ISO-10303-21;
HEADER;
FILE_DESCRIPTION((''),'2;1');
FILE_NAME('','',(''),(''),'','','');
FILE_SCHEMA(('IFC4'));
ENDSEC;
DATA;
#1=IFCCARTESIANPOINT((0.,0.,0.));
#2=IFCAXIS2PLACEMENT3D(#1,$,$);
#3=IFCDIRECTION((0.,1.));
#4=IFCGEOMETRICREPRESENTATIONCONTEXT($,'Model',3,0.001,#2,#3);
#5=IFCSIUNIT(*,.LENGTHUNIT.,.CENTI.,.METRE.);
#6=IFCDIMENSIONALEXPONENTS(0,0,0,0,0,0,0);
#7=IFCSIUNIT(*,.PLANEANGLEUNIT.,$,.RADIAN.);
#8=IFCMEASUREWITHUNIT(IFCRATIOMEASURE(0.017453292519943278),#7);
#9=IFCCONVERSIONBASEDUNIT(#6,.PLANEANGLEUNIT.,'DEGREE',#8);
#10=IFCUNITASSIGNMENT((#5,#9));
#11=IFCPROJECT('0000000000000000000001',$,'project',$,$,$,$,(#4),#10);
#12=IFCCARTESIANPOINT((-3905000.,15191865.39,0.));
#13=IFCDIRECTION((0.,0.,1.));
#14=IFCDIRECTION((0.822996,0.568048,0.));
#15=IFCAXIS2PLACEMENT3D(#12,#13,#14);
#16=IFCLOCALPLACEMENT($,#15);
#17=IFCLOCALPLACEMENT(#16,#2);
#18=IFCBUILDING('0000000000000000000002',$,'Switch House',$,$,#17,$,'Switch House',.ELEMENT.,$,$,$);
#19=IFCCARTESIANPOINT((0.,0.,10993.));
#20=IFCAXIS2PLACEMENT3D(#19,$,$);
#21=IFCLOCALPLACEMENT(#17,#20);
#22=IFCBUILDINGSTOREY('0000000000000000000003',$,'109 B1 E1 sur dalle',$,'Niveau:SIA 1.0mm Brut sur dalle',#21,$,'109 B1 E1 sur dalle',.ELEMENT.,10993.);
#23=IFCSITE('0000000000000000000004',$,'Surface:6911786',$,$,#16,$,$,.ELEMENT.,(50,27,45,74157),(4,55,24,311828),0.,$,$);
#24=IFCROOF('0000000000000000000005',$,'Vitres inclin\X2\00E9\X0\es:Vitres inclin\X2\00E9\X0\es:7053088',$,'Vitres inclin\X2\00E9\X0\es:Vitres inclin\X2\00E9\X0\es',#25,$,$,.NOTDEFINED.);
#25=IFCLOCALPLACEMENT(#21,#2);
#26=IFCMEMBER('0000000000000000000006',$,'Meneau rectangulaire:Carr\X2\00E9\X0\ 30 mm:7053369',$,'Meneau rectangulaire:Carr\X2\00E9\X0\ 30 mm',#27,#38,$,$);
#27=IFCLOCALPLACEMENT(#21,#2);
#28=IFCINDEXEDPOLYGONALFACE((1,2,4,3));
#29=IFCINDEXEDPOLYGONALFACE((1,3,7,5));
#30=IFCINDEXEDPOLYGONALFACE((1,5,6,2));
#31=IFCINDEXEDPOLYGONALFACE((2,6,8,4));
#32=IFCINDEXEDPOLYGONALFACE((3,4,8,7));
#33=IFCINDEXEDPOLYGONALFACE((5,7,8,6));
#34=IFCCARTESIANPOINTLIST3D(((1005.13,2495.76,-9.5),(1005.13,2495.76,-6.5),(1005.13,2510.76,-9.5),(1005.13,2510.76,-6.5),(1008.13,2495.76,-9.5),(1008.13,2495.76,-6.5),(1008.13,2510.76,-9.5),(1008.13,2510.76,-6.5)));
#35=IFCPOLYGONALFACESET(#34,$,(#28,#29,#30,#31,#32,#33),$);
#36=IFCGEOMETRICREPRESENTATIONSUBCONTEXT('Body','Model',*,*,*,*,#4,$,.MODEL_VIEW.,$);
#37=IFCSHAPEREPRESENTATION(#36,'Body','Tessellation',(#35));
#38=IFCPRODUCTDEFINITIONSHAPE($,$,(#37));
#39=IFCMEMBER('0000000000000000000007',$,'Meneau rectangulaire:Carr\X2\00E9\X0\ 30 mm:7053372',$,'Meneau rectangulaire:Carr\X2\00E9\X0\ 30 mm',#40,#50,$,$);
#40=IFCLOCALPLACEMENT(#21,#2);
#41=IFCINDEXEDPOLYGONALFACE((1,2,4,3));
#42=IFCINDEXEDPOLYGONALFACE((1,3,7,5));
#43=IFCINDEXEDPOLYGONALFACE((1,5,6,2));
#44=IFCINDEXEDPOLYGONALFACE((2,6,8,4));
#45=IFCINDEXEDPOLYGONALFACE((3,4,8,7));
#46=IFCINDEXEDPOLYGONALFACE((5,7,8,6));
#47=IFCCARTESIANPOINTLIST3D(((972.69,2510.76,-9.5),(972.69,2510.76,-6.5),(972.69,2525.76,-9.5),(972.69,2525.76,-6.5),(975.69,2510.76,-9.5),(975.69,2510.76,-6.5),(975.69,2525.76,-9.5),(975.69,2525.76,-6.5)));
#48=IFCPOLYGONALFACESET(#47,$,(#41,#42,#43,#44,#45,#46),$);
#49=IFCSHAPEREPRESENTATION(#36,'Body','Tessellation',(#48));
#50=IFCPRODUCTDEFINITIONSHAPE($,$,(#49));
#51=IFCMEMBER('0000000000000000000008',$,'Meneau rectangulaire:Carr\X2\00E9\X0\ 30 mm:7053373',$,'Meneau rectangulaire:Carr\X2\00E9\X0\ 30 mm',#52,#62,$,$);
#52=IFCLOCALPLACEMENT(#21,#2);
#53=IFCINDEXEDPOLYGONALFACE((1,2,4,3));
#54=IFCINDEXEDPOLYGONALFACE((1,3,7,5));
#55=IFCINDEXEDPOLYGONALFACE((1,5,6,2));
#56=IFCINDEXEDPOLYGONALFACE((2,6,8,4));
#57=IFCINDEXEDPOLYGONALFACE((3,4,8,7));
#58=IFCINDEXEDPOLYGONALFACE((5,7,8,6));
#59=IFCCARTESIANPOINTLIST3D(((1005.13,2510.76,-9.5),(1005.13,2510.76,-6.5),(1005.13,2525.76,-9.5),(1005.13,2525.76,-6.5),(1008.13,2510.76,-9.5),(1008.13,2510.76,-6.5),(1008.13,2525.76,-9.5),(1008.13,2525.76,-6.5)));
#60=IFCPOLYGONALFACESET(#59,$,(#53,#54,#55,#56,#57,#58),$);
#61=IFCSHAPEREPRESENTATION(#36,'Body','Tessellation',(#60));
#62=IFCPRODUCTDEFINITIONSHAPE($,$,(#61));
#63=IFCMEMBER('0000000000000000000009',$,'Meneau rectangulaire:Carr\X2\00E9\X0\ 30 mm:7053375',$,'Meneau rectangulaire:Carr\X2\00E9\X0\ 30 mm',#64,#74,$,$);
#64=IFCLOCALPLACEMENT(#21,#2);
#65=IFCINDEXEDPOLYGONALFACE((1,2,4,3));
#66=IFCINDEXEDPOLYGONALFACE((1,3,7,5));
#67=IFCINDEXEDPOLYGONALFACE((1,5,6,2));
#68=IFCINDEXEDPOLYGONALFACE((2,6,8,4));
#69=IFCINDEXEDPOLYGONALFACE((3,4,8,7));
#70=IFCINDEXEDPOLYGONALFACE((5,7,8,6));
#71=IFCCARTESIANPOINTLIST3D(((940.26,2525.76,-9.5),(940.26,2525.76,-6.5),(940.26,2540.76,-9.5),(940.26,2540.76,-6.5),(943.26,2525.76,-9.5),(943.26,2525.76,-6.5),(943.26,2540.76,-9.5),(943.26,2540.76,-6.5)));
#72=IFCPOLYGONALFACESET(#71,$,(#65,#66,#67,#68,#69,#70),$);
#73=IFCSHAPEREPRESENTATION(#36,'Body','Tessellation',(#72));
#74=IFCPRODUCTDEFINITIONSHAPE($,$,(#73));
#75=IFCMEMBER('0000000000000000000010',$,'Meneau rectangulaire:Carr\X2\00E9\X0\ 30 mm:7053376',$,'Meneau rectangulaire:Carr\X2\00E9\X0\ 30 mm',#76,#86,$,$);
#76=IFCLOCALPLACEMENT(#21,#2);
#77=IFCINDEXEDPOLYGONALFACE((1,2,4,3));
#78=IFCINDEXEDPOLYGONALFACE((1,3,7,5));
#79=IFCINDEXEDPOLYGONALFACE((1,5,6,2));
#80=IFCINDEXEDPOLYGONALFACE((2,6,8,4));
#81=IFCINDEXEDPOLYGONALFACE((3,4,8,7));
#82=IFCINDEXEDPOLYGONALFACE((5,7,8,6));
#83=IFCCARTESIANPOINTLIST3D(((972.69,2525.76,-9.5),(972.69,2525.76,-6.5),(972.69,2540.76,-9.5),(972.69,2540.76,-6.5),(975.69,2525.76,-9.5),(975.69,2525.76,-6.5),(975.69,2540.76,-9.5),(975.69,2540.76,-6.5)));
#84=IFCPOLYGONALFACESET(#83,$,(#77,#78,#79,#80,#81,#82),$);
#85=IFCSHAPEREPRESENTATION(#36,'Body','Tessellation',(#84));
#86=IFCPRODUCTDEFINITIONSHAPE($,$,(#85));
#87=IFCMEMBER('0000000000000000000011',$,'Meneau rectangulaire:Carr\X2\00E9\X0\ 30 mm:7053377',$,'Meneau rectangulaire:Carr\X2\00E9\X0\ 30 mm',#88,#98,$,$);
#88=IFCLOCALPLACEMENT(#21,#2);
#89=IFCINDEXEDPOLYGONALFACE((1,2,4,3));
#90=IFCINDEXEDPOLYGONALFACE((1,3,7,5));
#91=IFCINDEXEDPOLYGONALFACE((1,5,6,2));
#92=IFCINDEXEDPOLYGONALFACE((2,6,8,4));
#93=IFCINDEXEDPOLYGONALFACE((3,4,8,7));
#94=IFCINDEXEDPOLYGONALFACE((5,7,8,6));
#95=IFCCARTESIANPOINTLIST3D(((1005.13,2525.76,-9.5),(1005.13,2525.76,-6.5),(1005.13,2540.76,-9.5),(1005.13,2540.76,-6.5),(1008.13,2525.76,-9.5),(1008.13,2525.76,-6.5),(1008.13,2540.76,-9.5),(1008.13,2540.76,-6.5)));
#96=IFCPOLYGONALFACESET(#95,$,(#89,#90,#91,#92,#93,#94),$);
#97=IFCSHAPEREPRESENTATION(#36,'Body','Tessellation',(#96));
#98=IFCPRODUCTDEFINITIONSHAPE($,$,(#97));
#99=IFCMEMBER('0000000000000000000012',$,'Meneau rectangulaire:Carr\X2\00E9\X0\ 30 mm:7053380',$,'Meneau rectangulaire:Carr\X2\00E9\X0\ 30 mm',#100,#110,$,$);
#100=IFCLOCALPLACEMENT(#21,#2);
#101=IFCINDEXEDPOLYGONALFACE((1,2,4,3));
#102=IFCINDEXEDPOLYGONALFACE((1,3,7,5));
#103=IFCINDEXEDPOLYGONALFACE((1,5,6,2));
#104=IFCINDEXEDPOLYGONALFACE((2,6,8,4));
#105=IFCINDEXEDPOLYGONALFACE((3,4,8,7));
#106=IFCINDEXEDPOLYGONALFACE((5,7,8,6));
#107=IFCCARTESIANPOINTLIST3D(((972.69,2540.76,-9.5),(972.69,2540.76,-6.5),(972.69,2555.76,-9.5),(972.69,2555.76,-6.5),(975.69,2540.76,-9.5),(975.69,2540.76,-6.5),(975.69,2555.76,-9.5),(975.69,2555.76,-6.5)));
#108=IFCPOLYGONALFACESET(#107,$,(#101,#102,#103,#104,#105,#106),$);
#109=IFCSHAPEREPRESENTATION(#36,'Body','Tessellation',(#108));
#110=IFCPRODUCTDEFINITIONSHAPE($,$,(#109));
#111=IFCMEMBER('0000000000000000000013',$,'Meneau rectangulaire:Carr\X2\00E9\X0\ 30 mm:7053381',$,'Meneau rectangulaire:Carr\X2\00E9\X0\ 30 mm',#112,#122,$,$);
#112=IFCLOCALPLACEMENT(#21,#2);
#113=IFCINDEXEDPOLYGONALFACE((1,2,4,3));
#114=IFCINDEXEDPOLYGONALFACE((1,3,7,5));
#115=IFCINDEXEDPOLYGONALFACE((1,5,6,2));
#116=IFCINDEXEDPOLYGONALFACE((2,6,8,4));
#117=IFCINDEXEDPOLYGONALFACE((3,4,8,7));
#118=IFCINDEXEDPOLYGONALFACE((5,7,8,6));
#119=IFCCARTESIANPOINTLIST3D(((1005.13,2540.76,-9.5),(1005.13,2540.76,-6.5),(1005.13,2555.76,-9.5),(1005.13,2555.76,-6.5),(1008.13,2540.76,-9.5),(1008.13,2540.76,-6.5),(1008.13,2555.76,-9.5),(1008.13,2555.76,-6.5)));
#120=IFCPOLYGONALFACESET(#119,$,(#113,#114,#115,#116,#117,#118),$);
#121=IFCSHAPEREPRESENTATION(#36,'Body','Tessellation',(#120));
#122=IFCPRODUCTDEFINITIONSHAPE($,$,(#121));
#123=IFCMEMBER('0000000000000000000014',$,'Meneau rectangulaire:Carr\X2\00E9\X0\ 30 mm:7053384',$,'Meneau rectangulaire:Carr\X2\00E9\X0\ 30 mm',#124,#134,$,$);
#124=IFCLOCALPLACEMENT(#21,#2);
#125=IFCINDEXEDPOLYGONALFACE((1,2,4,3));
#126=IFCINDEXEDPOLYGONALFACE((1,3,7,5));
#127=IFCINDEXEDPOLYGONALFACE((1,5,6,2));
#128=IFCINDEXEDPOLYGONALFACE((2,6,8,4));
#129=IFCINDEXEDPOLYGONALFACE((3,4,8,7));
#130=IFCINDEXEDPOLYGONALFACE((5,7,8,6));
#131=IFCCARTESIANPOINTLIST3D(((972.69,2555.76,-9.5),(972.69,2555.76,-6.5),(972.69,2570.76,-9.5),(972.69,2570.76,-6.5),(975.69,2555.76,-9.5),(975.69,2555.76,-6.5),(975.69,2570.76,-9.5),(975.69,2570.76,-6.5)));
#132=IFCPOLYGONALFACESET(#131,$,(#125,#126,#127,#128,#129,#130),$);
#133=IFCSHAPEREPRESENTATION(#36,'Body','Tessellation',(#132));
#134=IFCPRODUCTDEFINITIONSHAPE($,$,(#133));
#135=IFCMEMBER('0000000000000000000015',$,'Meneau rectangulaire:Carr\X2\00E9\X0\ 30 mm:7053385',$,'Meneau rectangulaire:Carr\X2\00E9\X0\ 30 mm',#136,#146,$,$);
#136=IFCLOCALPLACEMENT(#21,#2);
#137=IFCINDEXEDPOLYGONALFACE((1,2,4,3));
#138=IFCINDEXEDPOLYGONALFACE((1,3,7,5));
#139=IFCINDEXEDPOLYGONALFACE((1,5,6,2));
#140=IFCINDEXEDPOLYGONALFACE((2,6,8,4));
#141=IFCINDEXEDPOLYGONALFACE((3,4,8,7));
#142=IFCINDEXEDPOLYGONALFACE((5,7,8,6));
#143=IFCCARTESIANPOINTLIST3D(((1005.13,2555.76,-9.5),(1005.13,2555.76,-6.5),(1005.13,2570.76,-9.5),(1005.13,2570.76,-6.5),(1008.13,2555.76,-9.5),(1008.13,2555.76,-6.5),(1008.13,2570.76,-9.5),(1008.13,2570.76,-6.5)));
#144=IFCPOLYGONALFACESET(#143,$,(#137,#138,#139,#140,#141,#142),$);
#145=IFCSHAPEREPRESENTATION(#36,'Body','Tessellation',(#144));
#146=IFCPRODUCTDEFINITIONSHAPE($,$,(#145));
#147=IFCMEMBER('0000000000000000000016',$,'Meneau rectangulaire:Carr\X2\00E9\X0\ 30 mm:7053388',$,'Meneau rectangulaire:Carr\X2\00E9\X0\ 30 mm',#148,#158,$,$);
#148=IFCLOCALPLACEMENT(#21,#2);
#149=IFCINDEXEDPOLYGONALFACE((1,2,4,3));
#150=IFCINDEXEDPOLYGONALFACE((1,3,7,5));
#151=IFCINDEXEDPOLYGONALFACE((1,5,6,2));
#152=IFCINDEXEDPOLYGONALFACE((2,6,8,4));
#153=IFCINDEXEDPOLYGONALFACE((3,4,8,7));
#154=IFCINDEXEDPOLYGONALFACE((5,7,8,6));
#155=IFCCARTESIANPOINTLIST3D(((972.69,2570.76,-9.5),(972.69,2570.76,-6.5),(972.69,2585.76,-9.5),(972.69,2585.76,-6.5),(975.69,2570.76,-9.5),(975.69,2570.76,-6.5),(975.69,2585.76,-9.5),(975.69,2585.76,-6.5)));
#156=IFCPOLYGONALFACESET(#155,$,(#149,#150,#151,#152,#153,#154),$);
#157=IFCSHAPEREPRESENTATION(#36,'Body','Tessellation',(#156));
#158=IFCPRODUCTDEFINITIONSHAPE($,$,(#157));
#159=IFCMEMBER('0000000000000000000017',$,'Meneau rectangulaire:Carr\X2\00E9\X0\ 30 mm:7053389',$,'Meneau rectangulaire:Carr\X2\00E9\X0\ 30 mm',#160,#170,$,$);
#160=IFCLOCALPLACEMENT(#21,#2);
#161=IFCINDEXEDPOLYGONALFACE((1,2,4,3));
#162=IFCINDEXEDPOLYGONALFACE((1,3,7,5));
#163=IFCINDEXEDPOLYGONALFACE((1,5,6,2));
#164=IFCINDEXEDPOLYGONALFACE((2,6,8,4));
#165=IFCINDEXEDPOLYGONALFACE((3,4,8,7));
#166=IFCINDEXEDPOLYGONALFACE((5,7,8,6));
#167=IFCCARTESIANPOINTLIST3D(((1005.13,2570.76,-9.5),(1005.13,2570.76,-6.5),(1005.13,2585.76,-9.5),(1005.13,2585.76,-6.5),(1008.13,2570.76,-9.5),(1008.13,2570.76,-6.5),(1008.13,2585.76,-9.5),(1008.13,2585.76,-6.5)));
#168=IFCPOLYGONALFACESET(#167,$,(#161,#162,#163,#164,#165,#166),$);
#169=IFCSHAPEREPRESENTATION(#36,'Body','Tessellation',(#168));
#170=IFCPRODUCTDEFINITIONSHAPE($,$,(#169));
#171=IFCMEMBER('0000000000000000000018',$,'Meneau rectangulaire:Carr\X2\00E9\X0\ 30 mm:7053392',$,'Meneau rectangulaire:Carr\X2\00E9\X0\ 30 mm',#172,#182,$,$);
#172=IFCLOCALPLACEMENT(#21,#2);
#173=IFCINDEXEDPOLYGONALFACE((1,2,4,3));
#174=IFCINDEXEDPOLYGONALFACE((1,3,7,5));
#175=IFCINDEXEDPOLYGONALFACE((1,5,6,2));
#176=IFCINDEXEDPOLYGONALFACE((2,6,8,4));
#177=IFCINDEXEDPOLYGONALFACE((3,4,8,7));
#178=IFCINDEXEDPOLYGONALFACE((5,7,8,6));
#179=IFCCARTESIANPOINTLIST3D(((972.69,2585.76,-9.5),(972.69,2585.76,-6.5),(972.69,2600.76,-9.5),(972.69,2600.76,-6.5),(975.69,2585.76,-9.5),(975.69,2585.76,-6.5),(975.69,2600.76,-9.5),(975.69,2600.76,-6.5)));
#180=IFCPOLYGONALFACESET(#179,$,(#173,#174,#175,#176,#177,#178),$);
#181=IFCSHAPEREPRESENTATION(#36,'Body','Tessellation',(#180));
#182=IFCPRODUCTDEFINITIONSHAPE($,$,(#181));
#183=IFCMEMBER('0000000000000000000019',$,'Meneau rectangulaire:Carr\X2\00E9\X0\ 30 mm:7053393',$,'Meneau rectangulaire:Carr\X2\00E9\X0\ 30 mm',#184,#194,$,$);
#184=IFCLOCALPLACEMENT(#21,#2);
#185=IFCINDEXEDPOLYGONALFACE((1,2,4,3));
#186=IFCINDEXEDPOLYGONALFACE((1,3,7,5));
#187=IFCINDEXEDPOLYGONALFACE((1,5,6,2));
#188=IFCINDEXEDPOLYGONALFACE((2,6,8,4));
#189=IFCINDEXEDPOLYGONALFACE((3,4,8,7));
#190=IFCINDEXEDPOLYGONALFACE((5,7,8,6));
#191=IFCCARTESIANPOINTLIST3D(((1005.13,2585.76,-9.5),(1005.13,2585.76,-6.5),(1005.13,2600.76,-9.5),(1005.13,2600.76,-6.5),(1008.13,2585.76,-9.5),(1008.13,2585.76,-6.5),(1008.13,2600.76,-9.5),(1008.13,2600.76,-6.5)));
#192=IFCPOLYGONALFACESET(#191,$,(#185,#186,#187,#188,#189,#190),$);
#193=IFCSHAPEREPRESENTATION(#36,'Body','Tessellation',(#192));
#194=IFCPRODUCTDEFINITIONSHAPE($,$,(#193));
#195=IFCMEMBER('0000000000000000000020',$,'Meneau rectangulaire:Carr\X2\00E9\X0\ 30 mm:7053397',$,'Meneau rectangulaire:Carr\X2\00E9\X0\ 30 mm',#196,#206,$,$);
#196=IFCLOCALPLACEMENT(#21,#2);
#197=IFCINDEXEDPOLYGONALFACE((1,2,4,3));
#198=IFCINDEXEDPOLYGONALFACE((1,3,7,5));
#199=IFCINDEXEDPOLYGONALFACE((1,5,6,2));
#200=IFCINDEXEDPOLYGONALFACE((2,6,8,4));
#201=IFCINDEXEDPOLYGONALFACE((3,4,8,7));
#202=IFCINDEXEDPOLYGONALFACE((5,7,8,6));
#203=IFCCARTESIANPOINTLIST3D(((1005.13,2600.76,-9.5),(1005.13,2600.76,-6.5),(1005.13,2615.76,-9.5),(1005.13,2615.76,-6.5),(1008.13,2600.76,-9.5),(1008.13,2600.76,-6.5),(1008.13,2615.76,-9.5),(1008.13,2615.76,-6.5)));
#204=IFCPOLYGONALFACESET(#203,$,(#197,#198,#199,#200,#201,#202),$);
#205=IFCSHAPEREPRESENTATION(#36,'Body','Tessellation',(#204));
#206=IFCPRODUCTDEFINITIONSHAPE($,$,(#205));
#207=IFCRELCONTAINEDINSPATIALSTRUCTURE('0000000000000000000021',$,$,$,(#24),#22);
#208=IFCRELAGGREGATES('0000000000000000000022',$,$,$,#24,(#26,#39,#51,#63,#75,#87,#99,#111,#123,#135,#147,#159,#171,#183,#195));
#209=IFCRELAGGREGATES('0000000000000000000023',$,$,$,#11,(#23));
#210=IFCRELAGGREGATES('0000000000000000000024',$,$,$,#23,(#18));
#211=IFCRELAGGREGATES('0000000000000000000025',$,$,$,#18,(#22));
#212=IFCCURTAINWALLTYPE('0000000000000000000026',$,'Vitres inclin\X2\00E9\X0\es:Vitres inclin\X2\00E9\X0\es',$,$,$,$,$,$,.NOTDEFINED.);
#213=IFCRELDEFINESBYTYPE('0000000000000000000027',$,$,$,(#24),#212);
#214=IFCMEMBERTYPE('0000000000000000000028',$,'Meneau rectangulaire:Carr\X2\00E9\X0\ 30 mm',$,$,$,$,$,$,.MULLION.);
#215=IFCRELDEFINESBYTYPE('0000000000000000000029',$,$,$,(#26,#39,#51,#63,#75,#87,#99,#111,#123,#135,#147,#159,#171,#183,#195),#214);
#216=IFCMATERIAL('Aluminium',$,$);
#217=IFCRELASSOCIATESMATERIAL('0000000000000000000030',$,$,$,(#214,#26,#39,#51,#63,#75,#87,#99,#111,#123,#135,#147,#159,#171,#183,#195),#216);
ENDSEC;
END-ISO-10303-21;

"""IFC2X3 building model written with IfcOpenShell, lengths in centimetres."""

from ifc_helpers import new_model, entity, si_unit, converted_unit, direction, frame, origin, origin_2d_with_axis, place, context, subcontext, project, spatial, rectangle, extrude, source, transform, mapped, material, type_object, type_shapes, element, aggregate, save


model = new_model("IFC2X3")

# Units and contexts
model_context = context("Model", 3, precision=0.001, world=origin(), true_north=direction((0.0, 1.0)))
body_context = subcontext(model_context, "Body", "Model", "MODEL_VIEW")
ifc_project = project(units=[si_unit("LENGTHUNIT", "METRE", prefix="CENTI"), converted_unit("PLANEANGLEUNIT", "DEGREE", entity("IfcRatioMeasure", 0.017453292519943278), si_unit("PLANEANGLEUNIT", "RADIAN"), dimensions=[0, 0, 0, 0, 0, 0, 0])], contexts=[model_context])

# Site, building, storey
site_placement = place(None, frame((-3905000.0, 15191865.39, 0.0), z_axis=(0.0, 0.0, 1.0), x_axis=(0.822996, 0.568048, 0.0)))
site = spatial("IfcSite", under=ifc_project, at=site_placement, Name="Surface:6911786", CompositionType="ELEMENT", RefLatitude=(50, 27, 45, 74157), RefLongitude=(4, 55, 24, 311828), RefElevation=0.0)
building_placement = place(site_placement, origin())
building = spatial("IfcBuilding", under=site, at=building_placement, Name="Switch House", LongName="Switch House", CompositionType="ELEMENT")
storey_placement = place(building_placement, frame((0.0, 0.0, 10993.0)))
storey = spatial("IfcBuildingStorey", under=building, at=storey_placement, Name="109 B1 E1 sur dalle", ObjectType="Niveau:SIA 1.0mm Brut sur dalle", LongName="109 B1 E1 sur dalle", CompositionType="ELEMENT", Elevation=10993.0)

# Roof, members
curtain_wall_type = type_object("IfcCurtainWallType", Name="Vitres inclinées:Vitres inclinées", PredefinedType="NOTDEFINED")
roof_placement = place(storey_placement, frame((0.0, 0.0, -10993.0)))
roof = element("IfcRoof", 1, at=roof_placement, inside=storey, type_object=curtain_wall_type, Name="Vitres inclinées:Vitres inclinées:7053088", ObjectType="Vitres inclinées:Vitres inclinées", ShapeType="NOTDEFINED")
ifc_material = material(Name="Aluminium")
member_type_1 = type_object("IfcMemberType", Name="Meneau rectangulaire:Carré 30 mm", PredefinedType="MULLION", material=ifc_material)
shared_shape_1 = source(origin(), body_context, "Body", "SweptSolid", [
    extrude(rectangle(XDim=3.0, YDim=3.0, at=origin_2d_with_axis()), frame((0.0, 0.0, -15.0), z_axis=(0.0, 0.0, 1.0), x_axis=(0.0, -1.0, 0.0)), (0.0, 0.0, 1.0), 15.0),
])
type_shapes(member_type_1, [shared_shape_1])
member_1_placement = place(roof_placement, frame((1006.63, 2510.76, 10985.0), z_axis=(0.0, 1.0, 0.0), x_axis=(1.0, 0.0, 0.0)))
member_1 = element("IfcMember", 2, at=member_1_placement, type_object=member_type_1, material=ifc_material, Name="Meneau rectangulaire:Carré 30 mm:7053369", ObjectType="Meneau rectangulaire:Carré 30 mm", context=body_context, shape_type="MappedRepresentation", body=[
    mapped(shared_shape_1, transform((0.0, 0.0, 0.0), scale=1.0)),
])
member_2_placement = place(roof_placement, frame((974.19, 2525.76, 10985.0), z_axis=(0.0, 1.0, 0.0), x_axis=(1.0, 0.0, 0.0)))
member_2 = element("IfcMember", 3, at=member_2_placement, type_object=member_type_1, material=ifc_material, Name="Meneau rectangulaire:Carré 30 mm:7053372", ObjectType="Meneau rectangulaire:Carré 30 mm", context=body_context, shape_type="MappedRepresentation", body=[
    mapped(shared_shape_1, transform((0.0, 0.0, 0.0), scale=1.0)),
])
member_3_placement = place(roof_placement, frame((1006.63, 2525.76, 10985.0), z_axis=(0.0, 1.0, 0.0), x_axis=(1.0, 0.0, 0.0)))
member_3 = element("IfcMember", 4, at=member_3_placement, type_object=member_type_1, material=ifc_material, Name="Meneau rectangulaire:Carré 30 mm:7053373", ObjectType="Meneau rectangulaire:Carré 30 mm", context=body_context, shape_type="MappedRepresentation", body=[
    mapped(shared_shape_1, transform((0.0, 0.0, 0.0), scale=1.0)),
])
member_4_placement = place(roof_placement, frame((941.76, 2540.76, 10985.0), z_axis=(0.0, 1.0, 0.0), x_axis=(1.0, 0.0, 0.0)))
member_4 = element("IfcMember", 5, at=member_4_placement, type_object=member_type_1, material=ifc_material, Name="Meneau rectangulaire:Carré 30 mm:7053375", ObjectType="Meneau rectangulaire:Carré 30 mm", context=body_context, shape_type="MappedRepresentation", body=[
    mapped(shared_shape_1, transform((0.0, 0.0, 0.0), scale=1.0)),
])
member_5_placement = place(roof_placement, frame((974.19, 2540.76, 10985.0), z_axis=(0.0, 1.0, 0.0), x_axis=(1.0, 0.0, 0.0)))
member_5 = element("IfcMember", 6, at=member_5_placement, type_object=member_type_1, material=ifc_material, Name="Meneau rectangulaire:Carré 30 mm:7053376", ObjectType="Meneau rectangulaire:Carré 30 mm", context=body_context, shape_type="MappedRepresentation", body=[
    mapped(shared_shape_1, transform((0.0, 0.0, 0.0), scale=1.0)),
])
member_6_placement = place(roof_placement, frame((1006.63, 2540.76, 10985.0), z_axis=(0.0, 1.0, 0.0), x_axis=(1.0, 0.0, 0.0)))
member_6 = element("IfcMember", 7, at=member_6_placement, type_object=member_type_1, material=ifc_material, Name="Meneau rectangulaire:Carré 30 mm:7053377", ObjectType="Meneau rectangulaire:Carré 30 mm", context=body_context, shape_type="MappedRepresentation", body=[
    mapped(shared_shape_1, transform((0.0, 0.0, 0.0), scale=1.0)),
])
member_7_placement = place(roof_placement, frame((974.19, 2555.76, 10985.0), z_axis=(0.0, 1.0, 0.0), x_axis=(1.0, 0.0, 0.0)))
member_7 = element("IfcMember", 8, at=member_7_placement, type_object=member_type_1, material=ifc_material, Name="Meneau rectangulaire:Carré 30 mm:7053380", ObjectType="Meneau rectangulaire:Carré 30 mm", context=body_context, shape_type="MappedRepresentation", body=[
    mapped(shared_shape_1, transform((0.0, 0.0, 0.0), scale=1.0)),
])
member_8_placement = place(roof_placement, frame((1006.63, 2555.76, 10985.0), z_axis=(0.0, 1.0, 0.0), x_axis=(1.0, 0.0, 0.0)))
member_8 = element("IfcMember", 9, at=member_8_placement, type_object=member_type_1, material=ifc_material, Name="Meneau rectangulaire:Carré 30 mm:7053381", ObjectType="Meneau rectangulaire:Carré 30 mm", context=body_context, shape_type="MappedRepresentation", body=[
    mapped(shared_shape_1, transform((0.0, 0.0, 0.0), scale=1.0)),
])
member_9_placement = place(roof_placement, frame((974.19, 2570.76, 10985.0), z_axis=(0.0, 1.0, 0.0), x_axis=(1.0, 0.0, 0.0)))
member_9 = element("IfcMember", 10, at=member_9_placement, type_object=member_type_1, material=ifc_material, Name="Meneau rectangulaire:Carré 30 mm:7053384", ObjectType="Meneau rectangulaire:Carré 30 mm", context=body_context, shape_type="MappedRepresentation", body=[
    mapped(shared_shape_1, transform((0.0, 0.0, 0.0), scale=1.0)),
])
member_10_placement = place(roof_placement, frame((1006.63, 2570.76, 10985.0), z_axis=(0.0, 1.0, 0.0), x_axis=(1.0, 0.0, 0.0)))
member_10 = element("IfcMember", 11, at=member_10_placement, type_object=member_type_1, material=ifc_material, Name="Meneau rectangulaire:Carré 30 mm:7053385", ObjectType="Meneau rectangulaire:Carré 30 mm", context=body_context, shape_type="MappedRepresentation", body=[
    mapped(shared_shape_1, transform((0.0, 0.0, 0.0), scale=1.0)),
])
member_11_placement = place(roof_placement, frame((974.19, 2585.76, 10985.0), z_axis=(0.0, 1.0, 0.0), x_axis=(1.0, 0.0, 0.0)))
member_11 = element("IfcMember", 12, at=member_11_placement, type_object=member_type_1, material=ifc_material, Name="Meneau rectangulaire:Carré 30 mm:7053388", ObjectType="Meneau rectangulaire:Carré 30 mm", context=body_context, shape_type="MappedRepresentation", body=[
    mapped(shared_shape_1, transform((0.0, 0.0, 0.0), scale=1.0)),
])
member_12_placement = place(roof_placement, frame((1006.63, 2585.76, 10985.0), z_axis=(0.0, 1.0, 0.0), x_axis=(1.0, 0.0, 0.0)))
member_12 = element("IfcMember", 13, at=member_12_placement, type_object=member_type_1, material=ifc_material, Name="Meneau rectangulaire:Carré 30 mm:7053389", ObjectType="Meneau rectangulaire:Carré 30 mm", context=body_context, shape_type="MappedRepresentation", body=[
    mapped(shared_shape_1, transform((0.0, 0.0, 0.0), scale=1.0)),
])
member_13_placement = place(roof_placement, frame((974.19, 2600.76, 10985.0), z_axis=(0.0, 1.0, 0.0), x_axis=(1.0, 0.0, 0.0)))
member_13 = element("IfcMember", 14, at=member_13_placement, type_object=member_type_1, material=ifc_material, Name="Meneau rectangulaire:Carré 30 mm:7053392", ObjectType="Meneau rectangulaire:Carré 30 mm", context=body_context, shape_type="MappedRepresentation", body=[
    mapped(shared_shape_1, transform((0.0, 0.0, 0.0), scale=1.0)),
])
member_14_placement = place(roof_placement, frame((1006.63, 2600.76, 10985.0), z_axis=(0.0, 1.0, 0.0), x_axis=(1.0, 0.0, 0.0)))
member_14 = element("IfcMember", 15, at=member_14_placement, type_object=member_type_1, material=ifc_material, Name="Meneau rectangulaire:Carré 30 mm:7053393", ObjectType="Meneau rectangulaire:Carré 30 mm", context=body_context, shape_type="MappedRepresentation", body=[
    mapped(shared_shape_1, transform((0.0, 0.0, 0.0), scale=1.0)),
])
member_15_placement = place(roof_placement, frame((1006.63, 2615.76, 10985.0), z_axis=(0.0, 1.0, 0.0), x_axis=(1.0, 0.0, 0.0)))
member_15 = element("IfcMember", 16, at=member_15_placement, type_object=member_type_1, material=ifc_material, Name="Meneau rectangulaire:Carré 30 mm:7053397", ObjectType="Meneau rectangulaire:Carré 30 mm", context=body_context, shape_type="MappedRepresentation", body=[
    mapped(shared_shape_1, transform((0.0, 0.0, 0.0), scale=1.0)),
])
aggregate(roof, [member_1, member_2, member_3, member_4, member_5, member_6, member_7, member_8, member_9, member_10, member_11, member_12, member_13, member_14, member_15])

save(model, "model.ifc")
